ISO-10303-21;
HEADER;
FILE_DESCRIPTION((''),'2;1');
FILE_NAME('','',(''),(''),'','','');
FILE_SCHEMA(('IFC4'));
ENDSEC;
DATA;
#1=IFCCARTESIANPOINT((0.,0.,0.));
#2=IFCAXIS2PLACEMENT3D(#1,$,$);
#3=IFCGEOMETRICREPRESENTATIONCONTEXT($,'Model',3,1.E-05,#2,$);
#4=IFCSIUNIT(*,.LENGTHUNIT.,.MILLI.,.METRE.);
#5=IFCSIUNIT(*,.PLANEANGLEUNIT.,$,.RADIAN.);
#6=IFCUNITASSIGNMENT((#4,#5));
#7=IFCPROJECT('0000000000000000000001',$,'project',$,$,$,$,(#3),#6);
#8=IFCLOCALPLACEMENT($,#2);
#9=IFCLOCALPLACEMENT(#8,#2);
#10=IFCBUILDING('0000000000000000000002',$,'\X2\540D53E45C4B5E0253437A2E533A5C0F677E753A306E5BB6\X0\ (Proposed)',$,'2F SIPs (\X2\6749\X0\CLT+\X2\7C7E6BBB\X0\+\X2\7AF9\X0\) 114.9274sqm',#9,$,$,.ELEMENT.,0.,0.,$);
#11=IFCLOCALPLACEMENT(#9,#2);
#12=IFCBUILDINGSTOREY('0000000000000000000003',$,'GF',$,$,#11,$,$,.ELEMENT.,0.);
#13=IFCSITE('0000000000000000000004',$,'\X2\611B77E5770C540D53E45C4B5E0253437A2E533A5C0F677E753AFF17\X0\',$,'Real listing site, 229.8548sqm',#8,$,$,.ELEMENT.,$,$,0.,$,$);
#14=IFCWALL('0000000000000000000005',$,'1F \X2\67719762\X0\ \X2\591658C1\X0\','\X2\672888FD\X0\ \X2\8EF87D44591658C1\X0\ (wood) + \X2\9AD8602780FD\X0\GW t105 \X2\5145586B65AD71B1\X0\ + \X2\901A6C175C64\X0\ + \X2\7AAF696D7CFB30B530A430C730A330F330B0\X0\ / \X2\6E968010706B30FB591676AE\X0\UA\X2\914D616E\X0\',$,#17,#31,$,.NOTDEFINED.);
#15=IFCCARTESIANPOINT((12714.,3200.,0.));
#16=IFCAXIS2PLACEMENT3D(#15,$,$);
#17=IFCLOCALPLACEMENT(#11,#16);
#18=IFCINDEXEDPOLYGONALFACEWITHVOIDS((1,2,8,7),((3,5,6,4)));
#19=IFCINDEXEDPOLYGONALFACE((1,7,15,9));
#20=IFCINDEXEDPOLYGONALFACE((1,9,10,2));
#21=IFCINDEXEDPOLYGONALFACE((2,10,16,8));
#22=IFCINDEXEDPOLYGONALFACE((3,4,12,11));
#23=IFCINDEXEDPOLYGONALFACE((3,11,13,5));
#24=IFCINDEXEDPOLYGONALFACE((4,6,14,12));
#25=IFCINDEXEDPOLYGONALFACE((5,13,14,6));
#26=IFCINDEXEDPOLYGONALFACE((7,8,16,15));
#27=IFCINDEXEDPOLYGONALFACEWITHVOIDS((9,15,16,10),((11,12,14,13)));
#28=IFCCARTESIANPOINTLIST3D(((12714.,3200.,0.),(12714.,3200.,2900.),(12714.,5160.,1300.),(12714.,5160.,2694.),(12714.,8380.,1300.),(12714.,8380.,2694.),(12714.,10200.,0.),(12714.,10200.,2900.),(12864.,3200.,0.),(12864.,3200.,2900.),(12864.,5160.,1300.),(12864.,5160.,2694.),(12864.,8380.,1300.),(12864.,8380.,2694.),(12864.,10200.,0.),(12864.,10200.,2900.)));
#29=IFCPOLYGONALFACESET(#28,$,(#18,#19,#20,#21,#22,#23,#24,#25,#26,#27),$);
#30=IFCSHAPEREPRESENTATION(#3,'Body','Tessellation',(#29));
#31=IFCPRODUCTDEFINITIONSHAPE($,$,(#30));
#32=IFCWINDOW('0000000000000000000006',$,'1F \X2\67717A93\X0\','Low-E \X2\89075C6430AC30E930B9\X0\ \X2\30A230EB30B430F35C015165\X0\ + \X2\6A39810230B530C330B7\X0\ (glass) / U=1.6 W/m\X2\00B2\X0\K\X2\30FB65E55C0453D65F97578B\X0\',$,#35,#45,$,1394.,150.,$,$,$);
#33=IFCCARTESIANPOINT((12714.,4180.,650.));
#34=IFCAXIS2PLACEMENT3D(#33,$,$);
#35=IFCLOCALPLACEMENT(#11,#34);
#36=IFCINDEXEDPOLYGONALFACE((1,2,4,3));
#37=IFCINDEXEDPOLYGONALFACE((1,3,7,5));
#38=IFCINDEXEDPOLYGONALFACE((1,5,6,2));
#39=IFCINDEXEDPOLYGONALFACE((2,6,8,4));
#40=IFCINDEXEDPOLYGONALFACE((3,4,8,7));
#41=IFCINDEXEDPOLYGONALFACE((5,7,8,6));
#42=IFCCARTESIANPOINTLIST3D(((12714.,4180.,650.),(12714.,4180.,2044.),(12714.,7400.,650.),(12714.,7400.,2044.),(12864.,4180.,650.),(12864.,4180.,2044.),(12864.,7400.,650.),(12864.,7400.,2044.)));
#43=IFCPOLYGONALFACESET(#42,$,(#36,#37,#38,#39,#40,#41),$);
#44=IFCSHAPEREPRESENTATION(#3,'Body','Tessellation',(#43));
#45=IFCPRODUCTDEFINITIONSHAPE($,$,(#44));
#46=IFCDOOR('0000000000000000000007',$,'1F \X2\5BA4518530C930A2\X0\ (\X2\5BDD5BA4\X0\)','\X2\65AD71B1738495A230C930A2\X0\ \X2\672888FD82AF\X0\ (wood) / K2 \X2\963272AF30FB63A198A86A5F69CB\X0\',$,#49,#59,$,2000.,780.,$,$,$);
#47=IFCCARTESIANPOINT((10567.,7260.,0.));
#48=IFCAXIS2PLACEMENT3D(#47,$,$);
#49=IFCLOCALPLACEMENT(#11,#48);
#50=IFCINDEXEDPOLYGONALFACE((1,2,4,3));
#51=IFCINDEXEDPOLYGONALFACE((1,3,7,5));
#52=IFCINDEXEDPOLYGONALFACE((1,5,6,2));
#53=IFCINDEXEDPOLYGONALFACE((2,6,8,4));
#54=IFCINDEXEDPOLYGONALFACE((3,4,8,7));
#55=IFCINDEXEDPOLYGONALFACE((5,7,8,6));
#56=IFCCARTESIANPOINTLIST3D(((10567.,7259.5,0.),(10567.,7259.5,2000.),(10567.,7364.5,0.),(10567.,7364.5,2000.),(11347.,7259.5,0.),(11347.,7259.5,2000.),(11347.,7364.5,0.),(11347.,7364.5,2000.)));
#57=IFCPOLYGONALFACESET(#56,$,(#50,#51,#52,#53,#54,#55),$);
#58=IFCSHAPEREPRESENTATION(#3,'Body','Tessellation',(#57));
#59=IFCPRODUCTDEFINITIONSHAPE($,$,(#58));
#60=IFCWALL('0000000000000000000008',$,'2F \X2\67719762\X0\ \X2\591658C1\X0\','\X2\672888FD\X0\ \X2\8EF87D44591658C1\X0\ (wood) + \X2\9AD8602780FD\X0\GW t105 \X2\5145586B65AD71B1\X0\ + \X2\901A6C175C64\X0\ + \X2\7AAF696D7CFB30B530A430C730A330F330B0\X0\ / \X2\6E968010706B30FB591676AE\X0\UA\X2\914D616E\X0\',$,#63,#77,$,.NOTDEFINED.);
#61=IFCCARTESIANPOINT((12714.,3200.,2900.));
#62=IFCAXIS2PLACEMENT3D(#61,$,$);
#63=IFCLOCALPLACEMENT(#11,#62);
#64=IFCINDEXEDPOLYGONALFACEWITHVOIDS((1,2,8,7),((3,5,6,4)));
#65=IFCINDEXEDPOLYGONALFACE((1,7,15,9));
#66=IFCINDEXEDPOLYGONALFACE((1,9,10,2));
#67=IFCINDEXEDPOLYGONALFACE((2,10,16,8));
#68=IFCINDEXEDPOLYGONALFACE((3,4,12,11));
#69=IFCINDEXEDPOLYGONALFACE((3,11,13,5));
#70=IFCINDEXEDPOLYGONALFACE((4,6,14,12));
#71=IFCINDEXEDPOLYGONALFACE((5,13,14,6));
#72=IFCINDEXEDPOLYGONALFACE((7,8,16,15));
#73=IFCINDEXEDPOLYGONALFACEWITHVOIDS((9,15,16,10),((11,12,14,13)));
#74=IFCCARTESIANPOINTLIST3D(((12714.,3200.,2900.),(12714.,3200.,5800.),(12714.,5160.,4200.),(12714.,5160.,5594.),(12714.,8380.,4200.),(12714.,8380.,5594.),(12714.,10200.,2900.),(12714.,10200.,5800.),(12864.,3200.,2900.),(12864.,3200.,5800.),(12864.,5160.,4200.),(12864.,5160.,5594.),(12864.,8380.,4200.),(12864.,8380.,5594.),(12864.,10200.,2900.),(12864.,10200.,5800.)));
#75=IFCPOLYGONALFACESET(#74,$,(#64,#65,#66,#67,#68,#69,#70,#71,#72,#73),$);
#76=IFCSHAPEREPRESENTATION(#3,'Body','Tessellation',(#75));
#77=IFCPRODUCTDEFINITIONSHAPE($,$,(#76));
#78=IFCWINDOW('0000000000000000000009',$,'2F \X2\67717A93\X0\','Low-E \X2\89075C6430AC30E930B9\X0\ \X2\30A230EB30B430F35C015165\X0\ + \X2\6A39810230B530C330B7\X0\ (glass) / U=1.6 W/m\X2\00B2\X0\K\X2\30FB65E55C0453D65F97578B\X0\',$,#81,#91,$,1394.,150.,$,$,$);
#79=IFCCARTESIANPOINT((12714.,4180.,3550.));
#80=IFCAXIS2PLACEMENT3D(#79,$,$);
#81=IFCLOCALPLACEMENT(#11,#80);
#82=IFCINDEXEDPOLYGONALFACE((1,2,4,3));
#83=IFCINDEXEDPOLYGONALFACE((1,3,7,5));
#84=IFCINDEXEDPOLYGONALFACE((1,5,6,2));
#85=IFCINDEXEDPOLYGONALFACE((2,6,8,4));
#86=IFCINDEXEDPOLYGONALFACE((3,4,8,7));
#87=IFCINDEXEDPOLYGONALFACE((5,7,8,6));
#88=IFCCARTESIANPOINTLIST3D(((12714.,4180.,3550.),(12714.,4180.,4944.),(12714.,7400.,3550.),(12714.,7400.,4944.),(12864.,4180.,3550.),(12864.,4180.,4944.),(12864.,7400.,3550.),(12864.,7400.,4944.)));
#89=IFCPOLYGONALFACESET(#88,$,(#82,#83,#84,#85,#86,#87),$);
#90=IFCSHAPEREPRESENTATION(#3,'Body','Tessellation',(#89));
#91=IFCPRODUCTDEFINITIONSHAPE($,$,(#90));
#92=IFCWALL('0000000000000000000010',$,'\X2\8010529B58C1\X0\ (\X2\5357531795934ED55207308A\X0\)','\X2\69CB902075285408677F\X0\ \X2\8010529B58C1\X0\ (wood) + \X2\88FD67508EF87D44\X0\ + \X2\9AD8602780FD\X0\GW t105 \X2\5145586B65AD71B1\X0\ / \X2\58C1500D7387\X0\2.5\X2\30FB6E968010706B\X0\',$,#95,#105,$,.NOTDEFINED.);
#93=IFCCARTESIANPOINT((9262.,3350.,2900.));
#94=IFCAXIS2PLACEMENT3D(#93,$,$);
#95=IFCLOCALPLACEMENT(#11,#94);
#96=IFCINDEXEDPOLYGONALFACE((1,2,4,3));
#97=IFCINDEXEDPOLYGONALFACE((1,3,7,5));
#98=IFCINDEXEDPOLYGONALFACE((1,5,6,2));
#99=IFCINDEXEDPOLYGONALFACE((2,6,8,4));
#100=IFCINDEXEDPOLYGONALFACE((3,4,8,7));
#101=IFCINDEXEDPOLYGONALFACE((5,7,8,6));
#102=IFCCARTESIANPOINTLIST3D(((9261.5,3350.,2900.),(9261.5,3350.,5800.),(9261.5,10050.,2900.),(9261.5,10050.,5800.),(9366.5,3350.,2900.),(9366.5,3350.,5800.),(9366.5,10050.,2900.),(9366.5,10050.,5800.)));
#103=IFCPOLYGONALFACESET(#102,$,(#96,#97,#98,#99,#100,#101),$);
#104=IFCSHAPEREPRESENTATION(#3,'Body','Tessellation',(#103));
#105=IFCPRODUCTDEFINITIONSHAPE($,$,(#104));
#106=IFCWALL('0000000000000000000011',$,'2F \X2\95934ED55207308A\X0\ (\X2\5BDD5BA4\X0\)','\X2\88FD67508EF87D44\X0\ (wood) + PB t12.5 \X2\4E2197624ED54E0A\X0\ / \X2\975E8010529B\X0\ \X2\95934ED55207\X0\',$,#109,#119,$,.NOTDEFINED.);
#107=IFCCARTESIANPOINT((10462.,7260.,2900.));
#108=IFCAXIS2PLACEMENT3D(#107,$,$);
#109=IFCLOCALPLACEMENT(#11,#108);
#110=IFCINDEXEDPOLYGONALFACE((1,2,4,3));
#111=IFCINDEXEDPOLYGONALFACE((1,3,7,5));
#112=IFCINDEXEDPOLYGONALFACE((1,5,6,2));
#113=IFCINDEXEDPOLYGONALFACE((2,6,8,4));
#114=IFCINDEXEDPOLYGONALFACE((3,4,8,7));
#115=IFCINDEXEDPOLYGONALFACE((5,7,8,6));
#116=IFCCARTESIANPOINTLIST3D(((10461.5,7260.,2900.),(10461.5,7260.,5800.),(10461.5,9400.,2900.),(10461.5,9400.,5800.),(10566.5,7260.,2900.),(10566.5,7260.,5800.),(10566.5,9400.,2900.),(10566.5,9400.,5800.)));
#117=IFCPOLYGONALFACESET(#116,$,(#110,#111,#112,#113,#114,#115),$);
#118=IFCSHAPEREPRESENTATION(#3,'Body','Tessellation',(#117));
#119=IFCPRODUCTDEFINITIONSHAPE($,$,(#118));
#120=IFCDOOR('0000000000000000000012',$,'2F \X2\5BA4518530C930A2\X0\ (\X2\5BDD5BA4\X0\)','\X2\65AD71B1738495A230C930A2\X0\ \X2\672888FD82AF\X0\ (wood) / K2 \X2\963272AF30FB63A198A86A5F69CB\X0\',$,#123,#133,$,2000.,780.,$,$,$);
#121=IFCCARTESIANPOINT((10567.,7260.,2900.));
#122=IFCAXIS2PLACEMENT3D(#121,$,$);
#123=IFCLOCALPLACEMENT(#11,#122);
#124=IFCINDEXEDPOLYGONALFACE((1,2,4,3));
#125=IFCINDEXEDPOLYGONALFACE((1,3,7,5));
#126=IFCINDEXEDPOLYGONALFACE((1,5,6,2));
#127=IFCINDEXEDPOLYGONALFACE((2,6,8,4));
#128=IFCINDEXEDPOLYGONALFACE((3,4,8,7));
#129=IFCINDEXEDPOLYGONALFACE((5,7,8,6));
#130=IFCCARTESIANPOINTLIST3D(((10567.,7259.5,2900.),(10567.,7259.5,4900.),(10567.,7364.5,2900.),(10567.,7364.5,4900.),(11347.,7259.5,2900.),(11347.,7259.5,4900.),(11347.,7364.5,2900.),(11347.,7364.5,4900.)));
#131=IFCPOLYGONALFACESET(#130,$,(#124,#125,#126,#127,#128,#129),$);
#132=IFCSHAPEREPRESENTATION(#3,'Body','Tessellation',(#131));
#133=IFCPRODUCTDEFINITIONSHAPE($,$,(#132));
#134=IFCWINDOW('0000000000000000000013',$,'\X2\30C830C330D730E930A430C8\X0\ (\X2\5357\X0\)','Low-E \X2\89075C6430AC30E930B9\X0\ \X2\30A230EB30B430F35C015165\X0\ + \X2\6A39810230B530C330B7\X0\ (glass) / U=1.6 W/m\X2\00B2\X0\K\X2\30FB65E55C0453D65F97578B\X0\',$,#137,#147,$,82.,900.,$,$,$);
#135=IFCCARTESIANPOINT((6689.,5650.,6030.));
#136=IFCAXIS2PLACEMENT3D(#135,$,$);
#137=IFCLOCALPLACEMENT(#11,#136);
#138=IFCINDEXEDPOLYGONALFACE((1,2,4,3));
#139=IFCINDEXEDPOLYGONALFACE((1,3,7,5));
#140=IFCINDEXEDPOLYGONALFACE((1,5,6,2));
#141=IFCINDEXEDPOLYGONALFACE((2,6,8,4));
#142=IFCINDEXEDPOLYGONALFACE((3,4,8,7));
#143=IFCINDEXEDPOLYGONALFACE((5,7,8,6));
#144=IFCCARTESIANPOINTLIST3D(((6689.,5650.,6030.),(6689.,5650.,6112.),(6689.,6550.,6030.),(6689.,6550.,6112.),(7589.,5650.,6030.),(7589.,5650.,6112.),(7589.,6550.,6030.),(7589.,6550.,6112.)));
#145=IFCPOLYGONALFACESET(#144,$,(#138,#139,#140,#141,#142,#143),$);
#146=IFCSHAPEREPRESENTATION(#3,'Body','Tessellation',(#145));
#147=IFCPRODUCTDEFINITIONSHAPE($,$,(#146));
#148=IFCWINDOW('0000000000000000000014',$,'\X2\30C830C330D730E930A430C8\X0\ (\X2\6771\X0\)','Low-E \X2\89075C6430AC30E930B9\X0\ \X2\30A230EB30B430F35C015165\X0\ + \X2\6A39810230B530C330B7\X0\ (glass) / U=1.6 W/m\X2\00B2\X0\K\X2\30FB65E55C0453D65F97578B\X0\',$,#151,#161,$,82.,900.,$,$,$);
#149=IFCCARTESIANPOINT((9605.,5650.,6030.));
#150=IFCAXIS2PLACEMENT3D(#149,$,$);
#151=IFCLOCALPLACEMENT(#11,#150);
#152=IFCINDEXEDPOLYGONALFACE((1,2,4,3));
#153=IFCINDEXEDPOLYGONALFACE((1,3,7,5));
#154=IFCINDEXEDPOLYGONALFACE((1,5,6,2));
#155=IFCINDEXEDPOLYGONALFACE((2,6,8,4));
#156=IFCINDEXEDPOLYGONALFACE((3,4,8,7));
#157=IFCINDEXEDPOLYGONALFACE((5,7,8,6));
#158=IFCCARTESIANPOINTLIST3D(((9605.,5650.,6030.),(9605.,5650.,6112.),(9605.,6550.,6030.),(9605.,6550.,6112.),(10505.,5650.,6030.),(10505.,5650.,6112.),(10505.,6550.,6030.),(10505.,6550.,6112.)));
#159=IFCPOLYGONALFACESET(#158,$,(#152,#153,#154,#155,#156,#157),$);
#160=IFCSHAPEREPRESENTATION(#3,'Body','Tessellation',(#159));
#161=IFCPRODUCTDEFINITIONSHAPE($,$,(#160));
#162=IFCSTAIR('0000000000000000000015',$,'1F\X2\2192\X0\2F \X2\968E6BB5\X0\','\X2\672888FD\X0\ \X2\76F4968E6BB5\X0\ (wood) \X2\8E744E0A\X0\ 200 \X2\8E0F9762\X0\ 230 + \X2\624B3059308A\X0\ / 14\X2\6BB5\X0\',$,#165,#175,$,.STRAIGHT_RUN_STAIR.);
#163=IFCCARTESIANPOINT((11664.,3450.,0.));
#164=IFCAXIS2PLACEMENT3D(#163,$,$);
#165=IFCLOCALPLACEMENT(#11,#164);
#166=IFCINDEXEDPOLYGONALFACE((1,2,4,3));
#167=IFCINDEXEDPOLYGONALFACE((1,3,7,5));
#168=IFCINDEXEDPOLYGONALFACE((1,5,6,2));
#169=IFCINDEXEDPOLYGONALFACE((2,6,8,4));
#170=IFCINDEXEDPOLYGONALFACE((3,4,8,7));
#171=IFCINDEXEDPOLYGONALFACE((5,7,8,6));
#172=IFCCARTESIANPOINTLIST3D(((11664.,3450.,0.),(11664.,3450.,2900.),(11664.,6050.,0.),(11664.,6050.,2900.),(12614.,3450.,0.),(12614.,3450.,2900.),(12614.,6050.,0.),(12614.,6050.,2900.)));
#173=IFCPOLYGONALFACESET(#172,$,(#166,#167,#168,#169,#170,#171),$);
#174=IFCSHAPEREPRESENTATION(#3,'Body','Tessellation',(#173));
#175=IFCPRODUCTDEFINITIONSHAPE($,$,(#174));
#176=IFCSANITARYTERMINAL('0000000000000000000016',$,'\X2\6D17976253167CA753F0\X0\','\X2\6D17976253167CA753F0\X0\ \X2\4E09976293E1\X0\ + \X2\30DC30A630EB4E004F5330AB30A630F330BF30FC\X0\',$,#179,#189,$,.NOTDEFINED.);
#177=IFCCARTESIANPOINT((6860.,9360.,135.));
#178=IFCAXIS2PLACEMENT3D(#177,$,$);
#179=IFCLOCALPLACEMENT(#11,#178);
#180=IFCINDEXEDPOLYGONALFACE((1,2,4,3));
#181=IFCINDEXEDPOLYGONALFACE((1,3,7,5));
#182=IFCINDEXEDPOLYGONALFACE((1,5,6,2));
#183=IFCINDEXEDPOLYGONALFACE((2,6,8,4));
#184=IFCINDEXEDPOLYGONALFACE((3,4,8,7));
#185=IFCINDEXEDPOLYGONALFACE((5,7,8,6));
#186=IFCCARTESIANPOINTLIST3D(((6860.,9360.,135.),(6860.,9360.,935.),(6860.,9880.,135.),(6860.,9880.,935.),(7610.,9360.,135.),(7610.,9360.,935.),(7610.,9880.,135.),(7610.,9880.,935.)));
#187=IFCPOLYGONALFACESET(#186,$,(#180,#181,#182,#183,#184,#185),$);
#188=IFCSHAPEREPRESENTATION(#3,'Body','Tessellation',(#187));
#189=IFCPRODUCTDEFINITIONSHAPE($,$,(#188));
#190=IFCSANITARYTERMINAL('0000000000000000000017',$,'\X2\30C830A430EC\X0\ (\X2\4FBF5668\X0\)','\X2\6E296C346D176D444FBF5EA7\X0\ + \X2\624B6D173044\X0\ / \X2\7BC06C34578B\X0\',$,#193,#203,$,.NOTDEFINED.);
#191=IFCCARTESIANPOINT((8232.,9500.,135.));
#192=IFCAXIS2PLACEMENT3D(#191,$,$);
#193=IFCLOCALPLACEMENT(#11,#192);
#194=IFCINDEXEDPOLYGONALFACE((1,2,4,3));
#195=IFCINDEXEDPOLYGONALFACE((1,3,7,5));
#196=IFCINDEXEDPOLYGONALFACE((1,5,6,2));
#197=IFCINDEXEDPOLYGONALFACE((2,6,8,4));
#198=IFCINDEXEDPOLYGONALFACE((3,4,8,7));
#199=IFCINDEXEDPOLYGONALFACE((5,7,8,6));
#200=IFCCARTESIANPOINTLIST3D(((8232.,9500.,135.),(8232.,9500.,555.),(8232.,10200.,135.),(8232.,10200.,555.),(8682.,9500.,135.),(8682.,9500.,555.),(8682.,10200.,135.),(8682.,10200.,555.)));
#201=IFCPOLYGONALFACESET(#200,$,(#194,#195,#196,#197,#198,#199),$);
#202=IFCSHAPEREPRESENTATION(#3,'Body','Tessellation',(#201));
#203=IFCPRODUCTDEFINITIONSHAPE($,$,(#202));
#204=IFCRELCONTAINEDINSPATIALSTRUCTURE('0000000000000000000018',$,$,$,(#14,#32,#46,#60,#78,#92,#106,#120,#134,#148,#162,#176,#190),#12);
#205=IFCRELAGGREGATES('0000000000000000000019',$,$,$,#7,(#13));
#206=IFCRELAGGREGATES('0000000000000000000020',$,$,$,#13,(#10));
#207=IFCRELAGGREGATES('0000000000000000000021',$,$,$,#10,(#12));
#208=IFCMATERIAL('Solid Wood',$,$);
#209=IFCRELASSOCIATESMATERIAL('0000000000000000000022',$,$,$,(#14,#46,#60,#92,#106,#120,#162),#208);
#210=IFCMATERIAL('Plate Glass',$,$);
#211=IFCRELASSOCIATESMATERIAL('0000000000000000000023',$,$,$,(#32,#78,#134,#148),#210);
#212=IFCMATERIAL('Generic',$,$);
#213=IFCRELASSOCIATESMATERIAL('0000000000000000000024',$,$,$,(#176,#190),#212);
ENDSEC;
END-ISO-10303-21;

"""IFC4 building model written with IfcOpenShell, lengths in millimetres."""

from ifc_helpers import new_model, si_unit, frame, frame_2d, origin, place, context, project, spatial, rectangle, extrude, material, element, fill, save


model = new_model("IFC4")

# Units and contexts
model_context = context("Model", 3, precision=1e-05, world=origin())
ifc_project = project(units=[si_unit("LENGTHUNIT", "METRE", prefix="MILLI"), si_unit("PLANEANGLEUNIT", "RADIAN")], contexts=[model_context])

# Site, building, storey
site_placement = place(None, origin())
site = spatial("IfcSite", under=ifc_project, at=site_placement, Name="愛知県名古屋市千種区小松町７", ObjectType="Real listing site, 229.8548sqm", CompositionType="ELEMENT", RefElevation=0.0)
building_placement = place(site_placement, origin())
building = spatial("IfcBuilding", under=site, at=building_placement, Name="名古屋市千種区小松町の家 (Proposed)", ObjectType="2F SIPs (杉CLT+籾殻+竹) 114.9274sqm", CompositionType="ELEMENT", ElevationOfRefHeight=0.0, ElevationOfTerrain=0.0)
storey_placement = place(building_placement, origin())
storey = spatial("IfcBuildingStorey", under=building, at=storey_placement, Name="GF", CompositionType="ELEMENT", Elevation=0.0)

# Wall, opening, window
ifc_material_1 = material(Name="Solid Wood")
wall_1_placement = place(storey_placement, frame((12714.0, 3200.0, 0.0)))
wall_1 = element("IfcWall", 1, at=wall_1_placement, inside=storey, material=ifc_material_1, Name="1F 東面 外壁", Description="木製 軸組外壁 (wood) + 高性能GW t105 充填断熱 + 通気層 + 窯業系サイディング / 準耐火・外皮UA配慮", PredefinedType="NOTDEFINED", context=model_context, shape_type="SweptSolid", body=[
    extrude(rectangle(XDim=150.0, YDim=7000.0, at=frame_2d((75.0, 3500.0))), frame((12714.0, 3200.0, 0.0)), (0.0, 0.0, 1.0), 2900.0),
])
opening_1_placement = place(storey_placement, frame((12714.0, 4180.0, 650.0)))
opening_1 = element("IfcOpeningElement", 2, at=opening_1_placement, cuts=wall_1, PredefinedType="NOTDEFINED", context=model_context, shape_type="SweptSolid", body=[
    extrude(rectangle(XDim=150.0, YDim=3220.0, at=frame_2d((75.0, 1610.0))), frame((12714.0, 4180.0, 650.0)), (0.0, 0.0, 1.0), 1394.0),
])
ifc_material_2 = material(Name="Plate Glass")
window_1_placement = place(storey_placement, frame((12714.0, 4180.0, 650.0)))
window_1 = element("IfcWindow", 3, at=window_1_placement, inside=storey, material=ifc_material_2, Name="1F 東窓", Description="Low-E 複層ガラス アルゴン封入 + 樹脂サッシ (glass) / U=1.6 W/m²K・日射取得型", OverallHeight=1394.0, OverallWidth=150.0, context=model_context, shape_type="SweptSolid", body=[
    extrude(rectangle(XDim=150.0, YDim=3220.0, at=frame_2d((75.0, 1610.0))), frame((12714.0, 4180.0, 650.0)), (0.0, 0.0, 1.0), 1394.0),
])
fill(opening_1, window_1)

# Door
door_1_placement = place(storey_placement, frame((10567.0, 7260.0, 0.0)))
element("IfcDoor", 4, at=door_1_placement, inside=storey, material=ifc_material_1, Name="1F 室内ドア (寝室)", Description="断熱玄関ドア 木製芯 (wood) / K2 防犯・採風機構", OverallHeight=2000.0, OverallWidth=780.0, context=model_context, shape_type="SweptSolid", body=[
    extrude(rectangle(XDim=780.0, YDim=105.0, at=frame_2d((390.0, 52.0))), frame((10567.0, 7260.0, 0.0)), (0.0, 0.0, 1.0), 2000.0),
])

# Wall, opening, window
wall_2_placement = place(storey_placement, frame((12714.0, 3200.0, 2900.0)))
wall_2 = element("IfcWall", 5, at=wall_2_placement, inside=storey, material=ifc_material_1, Name="2F 東面 外壁", Description="木製 軸組外壁 (wood) + 高性能GW t105 充填断熱 + 通気層 + 窯業系サイディング / 準耐火・外皮UA配慮", PredefinedType="NOTDEFINED", context=model_context, shape_type="SweptSolid", body=[
    extrude(rectangle(XDim=150.0, YDim=7000.0, at=frame_2d((75.0, 3500.0))), frame((12714.0, 3200.0, 2900.0)), (0.0, 0.0, 1.0), 2900.0),
])
opening_2_placement = place(storey_placement, frame((12714.0, 4180.0, 3550.0)))
opening_2 = element("IfcOpeningElement", 6, at=opening_2_placement, cuts=wall_2, PredefinedType="NOTDEFINED", context=model_context, shape_type="SweptSolid", body=[
    extrude(rectangle(XDim=150.0, YDim=3220.0, at=frame_2d((75.0, 1610.0))), frame((12714.0, 4180.0, 3550.0)), (0.0, 0.0, 1.0), 1394.0),
])
window_2_placement = place(storey_placement, frame((12714.0, 4180.0, 3550.0)))
window_2 = element("IfcWindow", 7, at=window_2_placement, inside=storey, material=ifc_material_2, Name="2F 東窓", Description="Low-E 複層ガラス アルゴン封入 + 樹脂サッシ (glass) / U=1.6 W/m²K・日射取得型", OverallHeight=1394.0, OverallWidth=150.0, context=model_context, shape_type="SweptSolid", body=[
    extrude(rectangle(XDim=150.0, YDim=3220.0, at=frame_2d((75.0, 1610.0))), frame((12714.0, 4180.0, 3550.0)), (0.0, 0.0, 1.0), 1394.0),
])
fill(opening_2, window_2)

# Walls
wall_3_placement = place(storey_placement, frame((9262.0, 3350.0, 2900.0)))
element("IfcWall", 8, at=wall_3_placement, inside=storey, material=ifc_material_1, Name="耐力壁 (南北間仕切り)", Description="構造用合板 耐力壁 (wood) + 製材軸組 + 高性能GW t105 充填断熱 / 壁倍率2.5・準耐火", PredefinedType="NOTDEFINED", context=model_context, shape_type="SweptSolid", body=[
    extrude(rectangle(XDim=105.0, YDim=6700.0, at=frame_2d((52.0, 3350.0))), frame((9262.0, 3350.0, 2900.0)), (0.0, 0.0, 1.0), 2900.0),
])
wall_4_placement = place(storey_placement, frame((10462.0, 7260.0, 2900.0)))
element("IfcWall", 9, at=wall_4_placement, inside=storey, material=ifc_material_1, Name="2F 間仕切り (寝室)", Description="製材軸組 (wood) + PB t12.5 両面仕上 / 非耐力 間仕切", PredefinedType="NOTDEFINED", context=model_context, shape_type="SweptSolid", body=[
    extrude(rectangle(XDim=105.0, YDim=2140.0, at=frame_2d((52.0, 1070.0))), frame((10462.0, 7260.0, 2900.0)), (0.0, 0.0, 1.0), 2900.0),
])

# Door
door_2_placement = place(storey_placement, frame((10567.0, 7260.0, 2900.0)))
element("IfcDoor", 10, at=door_2_placement, inside=storey, material=ifc_material_1, Name="2F 室内ドア (寝室)", Description="断熱玄関ドア 木製芯 (wood) / K2 防犯・採風機構", OverallHeight=2000.0, OverallWidth=780.0, context=model_context, shape_type="SweptSolid", body=[
    extrude(rectangle(XDim=780.0, YDim=105.0, at=frame_2d((390.0, 52.0))), frame((10567.0, 7260.0, 2900.0)), (0.0, 0.0, 1.0), 2000.0),
])

# Windows
window_3_placement = place(storey_placement, frame((6689.0, 5650.0, 6030.0)))
element("IfcWindow", 11, at=window_3_placement, inside=storey, material=ifc_material_2, Name="トップライト (南)", Description="Low-E 複層ガラス アルゴン封入 + 樹脂サッシ (glass) / U=1.6 W/m²K・日射取得型", OverallHeight=82.0, OverallWidth=900.0, context=model_context, shape_type="SweptSolid", body=[
    extrude(rectangle(XDim=900.0, YDim=900.0, at=frame_2d((450.0, 450.0))), frame((6689.0, 5650.0, 6030.0)), (0.0, 0.0, 1.0), 82.0),
])
window_4_placement = place(storey_placement, frame((9605.0, 5650.0, 6030.0)))
element("IfcWindow", 12, at=window_4_placement, inside=storey, material=ifc_material_2, Name="トップライト (東)", Description="Low-E 複層ガラス アルゴン封入 + 樹脂サッシ (glass) / U=1.6 W/m²K・日射取得型", OverallHeight=82.0, OverallWidth=900.0, context=model_context, shape_type="SweptSolid", body=[
    extrude(rectangle(XDim=900.0, YDim=900.0, at=frame_2d((450.0, 450.0))), frame((9605.0, 5650.0, 6030.0)), (0.0, 0.0, 1.0), 82.0),
])

# Stair
stair_placement = place(storey_placement, frame((11664.0, 3450.0, 0.0)))
element("IfcStair", 13, at=stair_placement, inside=storey, material=ifc_material_1, Name="1F→2F 階段", Description="木製 直階段 (wood) 蹴上 200 踏面 230 + 手すり / 14段", PredefinedType="STRAIGHT_RUN_STAIR", context=model_context, shape_type="SweptSolid", body=[
    extrude(rectangle(XDim=950.0, YDim=2600.0, at=frame_2d((475.0, 1300.0))), frame((11664.0, 3450.0, 0.0)), (0.0, 0.0, 1.0), 2900.0),
])

# Sanitary terminals
ifc_material_3 = material(Name="Generic")
sanitary_terminal_1_placement = place(storey_placement, frame((6860.0, 9360.0, 135.0)))
element("IfcSanitaryTerminal", 14, at=sanitary_terminal_1_placement, inside=storey, material=ifc_material_3, Name="洗面化粧台", Description="洗面化粧台 三面鏡 + ボウル一体カウンター", PredefinedType="NOTDEFINED", context=model_context, shape_type="SweptSolid", body=[
    extrude(rectangle(XDim=750.0, YDim=520.0, at=frame_2d((375.0, 260.0))), frame((6860.0, 9360.0, 135.0)), (0.0, 0.0, 1.0), 800.0),
])
sanitary_terminal_2_placement = place(storey_placement, frame((8232.0, 9500.0, 135.0)))
element("IfcSanitaryTerminal", 15, at=sanitary_terminal_2_placement, inside=storey, material=ifc_material_3, Name="トイレ (便器)", Description="温水洗浄便座 + 手洗い / 節水型", PredefinedType="NOTDEFINED", context=model_context, shape_type="SweptSolid", body=[
    extrude(rectangle(XDim=450.0, YDim=700.0, at=frame_2d((225.0, 350.0))), frame((8232.0, 9500.0, 135.0)), (0.0, 0.0, 1.0), 420.0),
])

save(model, "model.ifc")
